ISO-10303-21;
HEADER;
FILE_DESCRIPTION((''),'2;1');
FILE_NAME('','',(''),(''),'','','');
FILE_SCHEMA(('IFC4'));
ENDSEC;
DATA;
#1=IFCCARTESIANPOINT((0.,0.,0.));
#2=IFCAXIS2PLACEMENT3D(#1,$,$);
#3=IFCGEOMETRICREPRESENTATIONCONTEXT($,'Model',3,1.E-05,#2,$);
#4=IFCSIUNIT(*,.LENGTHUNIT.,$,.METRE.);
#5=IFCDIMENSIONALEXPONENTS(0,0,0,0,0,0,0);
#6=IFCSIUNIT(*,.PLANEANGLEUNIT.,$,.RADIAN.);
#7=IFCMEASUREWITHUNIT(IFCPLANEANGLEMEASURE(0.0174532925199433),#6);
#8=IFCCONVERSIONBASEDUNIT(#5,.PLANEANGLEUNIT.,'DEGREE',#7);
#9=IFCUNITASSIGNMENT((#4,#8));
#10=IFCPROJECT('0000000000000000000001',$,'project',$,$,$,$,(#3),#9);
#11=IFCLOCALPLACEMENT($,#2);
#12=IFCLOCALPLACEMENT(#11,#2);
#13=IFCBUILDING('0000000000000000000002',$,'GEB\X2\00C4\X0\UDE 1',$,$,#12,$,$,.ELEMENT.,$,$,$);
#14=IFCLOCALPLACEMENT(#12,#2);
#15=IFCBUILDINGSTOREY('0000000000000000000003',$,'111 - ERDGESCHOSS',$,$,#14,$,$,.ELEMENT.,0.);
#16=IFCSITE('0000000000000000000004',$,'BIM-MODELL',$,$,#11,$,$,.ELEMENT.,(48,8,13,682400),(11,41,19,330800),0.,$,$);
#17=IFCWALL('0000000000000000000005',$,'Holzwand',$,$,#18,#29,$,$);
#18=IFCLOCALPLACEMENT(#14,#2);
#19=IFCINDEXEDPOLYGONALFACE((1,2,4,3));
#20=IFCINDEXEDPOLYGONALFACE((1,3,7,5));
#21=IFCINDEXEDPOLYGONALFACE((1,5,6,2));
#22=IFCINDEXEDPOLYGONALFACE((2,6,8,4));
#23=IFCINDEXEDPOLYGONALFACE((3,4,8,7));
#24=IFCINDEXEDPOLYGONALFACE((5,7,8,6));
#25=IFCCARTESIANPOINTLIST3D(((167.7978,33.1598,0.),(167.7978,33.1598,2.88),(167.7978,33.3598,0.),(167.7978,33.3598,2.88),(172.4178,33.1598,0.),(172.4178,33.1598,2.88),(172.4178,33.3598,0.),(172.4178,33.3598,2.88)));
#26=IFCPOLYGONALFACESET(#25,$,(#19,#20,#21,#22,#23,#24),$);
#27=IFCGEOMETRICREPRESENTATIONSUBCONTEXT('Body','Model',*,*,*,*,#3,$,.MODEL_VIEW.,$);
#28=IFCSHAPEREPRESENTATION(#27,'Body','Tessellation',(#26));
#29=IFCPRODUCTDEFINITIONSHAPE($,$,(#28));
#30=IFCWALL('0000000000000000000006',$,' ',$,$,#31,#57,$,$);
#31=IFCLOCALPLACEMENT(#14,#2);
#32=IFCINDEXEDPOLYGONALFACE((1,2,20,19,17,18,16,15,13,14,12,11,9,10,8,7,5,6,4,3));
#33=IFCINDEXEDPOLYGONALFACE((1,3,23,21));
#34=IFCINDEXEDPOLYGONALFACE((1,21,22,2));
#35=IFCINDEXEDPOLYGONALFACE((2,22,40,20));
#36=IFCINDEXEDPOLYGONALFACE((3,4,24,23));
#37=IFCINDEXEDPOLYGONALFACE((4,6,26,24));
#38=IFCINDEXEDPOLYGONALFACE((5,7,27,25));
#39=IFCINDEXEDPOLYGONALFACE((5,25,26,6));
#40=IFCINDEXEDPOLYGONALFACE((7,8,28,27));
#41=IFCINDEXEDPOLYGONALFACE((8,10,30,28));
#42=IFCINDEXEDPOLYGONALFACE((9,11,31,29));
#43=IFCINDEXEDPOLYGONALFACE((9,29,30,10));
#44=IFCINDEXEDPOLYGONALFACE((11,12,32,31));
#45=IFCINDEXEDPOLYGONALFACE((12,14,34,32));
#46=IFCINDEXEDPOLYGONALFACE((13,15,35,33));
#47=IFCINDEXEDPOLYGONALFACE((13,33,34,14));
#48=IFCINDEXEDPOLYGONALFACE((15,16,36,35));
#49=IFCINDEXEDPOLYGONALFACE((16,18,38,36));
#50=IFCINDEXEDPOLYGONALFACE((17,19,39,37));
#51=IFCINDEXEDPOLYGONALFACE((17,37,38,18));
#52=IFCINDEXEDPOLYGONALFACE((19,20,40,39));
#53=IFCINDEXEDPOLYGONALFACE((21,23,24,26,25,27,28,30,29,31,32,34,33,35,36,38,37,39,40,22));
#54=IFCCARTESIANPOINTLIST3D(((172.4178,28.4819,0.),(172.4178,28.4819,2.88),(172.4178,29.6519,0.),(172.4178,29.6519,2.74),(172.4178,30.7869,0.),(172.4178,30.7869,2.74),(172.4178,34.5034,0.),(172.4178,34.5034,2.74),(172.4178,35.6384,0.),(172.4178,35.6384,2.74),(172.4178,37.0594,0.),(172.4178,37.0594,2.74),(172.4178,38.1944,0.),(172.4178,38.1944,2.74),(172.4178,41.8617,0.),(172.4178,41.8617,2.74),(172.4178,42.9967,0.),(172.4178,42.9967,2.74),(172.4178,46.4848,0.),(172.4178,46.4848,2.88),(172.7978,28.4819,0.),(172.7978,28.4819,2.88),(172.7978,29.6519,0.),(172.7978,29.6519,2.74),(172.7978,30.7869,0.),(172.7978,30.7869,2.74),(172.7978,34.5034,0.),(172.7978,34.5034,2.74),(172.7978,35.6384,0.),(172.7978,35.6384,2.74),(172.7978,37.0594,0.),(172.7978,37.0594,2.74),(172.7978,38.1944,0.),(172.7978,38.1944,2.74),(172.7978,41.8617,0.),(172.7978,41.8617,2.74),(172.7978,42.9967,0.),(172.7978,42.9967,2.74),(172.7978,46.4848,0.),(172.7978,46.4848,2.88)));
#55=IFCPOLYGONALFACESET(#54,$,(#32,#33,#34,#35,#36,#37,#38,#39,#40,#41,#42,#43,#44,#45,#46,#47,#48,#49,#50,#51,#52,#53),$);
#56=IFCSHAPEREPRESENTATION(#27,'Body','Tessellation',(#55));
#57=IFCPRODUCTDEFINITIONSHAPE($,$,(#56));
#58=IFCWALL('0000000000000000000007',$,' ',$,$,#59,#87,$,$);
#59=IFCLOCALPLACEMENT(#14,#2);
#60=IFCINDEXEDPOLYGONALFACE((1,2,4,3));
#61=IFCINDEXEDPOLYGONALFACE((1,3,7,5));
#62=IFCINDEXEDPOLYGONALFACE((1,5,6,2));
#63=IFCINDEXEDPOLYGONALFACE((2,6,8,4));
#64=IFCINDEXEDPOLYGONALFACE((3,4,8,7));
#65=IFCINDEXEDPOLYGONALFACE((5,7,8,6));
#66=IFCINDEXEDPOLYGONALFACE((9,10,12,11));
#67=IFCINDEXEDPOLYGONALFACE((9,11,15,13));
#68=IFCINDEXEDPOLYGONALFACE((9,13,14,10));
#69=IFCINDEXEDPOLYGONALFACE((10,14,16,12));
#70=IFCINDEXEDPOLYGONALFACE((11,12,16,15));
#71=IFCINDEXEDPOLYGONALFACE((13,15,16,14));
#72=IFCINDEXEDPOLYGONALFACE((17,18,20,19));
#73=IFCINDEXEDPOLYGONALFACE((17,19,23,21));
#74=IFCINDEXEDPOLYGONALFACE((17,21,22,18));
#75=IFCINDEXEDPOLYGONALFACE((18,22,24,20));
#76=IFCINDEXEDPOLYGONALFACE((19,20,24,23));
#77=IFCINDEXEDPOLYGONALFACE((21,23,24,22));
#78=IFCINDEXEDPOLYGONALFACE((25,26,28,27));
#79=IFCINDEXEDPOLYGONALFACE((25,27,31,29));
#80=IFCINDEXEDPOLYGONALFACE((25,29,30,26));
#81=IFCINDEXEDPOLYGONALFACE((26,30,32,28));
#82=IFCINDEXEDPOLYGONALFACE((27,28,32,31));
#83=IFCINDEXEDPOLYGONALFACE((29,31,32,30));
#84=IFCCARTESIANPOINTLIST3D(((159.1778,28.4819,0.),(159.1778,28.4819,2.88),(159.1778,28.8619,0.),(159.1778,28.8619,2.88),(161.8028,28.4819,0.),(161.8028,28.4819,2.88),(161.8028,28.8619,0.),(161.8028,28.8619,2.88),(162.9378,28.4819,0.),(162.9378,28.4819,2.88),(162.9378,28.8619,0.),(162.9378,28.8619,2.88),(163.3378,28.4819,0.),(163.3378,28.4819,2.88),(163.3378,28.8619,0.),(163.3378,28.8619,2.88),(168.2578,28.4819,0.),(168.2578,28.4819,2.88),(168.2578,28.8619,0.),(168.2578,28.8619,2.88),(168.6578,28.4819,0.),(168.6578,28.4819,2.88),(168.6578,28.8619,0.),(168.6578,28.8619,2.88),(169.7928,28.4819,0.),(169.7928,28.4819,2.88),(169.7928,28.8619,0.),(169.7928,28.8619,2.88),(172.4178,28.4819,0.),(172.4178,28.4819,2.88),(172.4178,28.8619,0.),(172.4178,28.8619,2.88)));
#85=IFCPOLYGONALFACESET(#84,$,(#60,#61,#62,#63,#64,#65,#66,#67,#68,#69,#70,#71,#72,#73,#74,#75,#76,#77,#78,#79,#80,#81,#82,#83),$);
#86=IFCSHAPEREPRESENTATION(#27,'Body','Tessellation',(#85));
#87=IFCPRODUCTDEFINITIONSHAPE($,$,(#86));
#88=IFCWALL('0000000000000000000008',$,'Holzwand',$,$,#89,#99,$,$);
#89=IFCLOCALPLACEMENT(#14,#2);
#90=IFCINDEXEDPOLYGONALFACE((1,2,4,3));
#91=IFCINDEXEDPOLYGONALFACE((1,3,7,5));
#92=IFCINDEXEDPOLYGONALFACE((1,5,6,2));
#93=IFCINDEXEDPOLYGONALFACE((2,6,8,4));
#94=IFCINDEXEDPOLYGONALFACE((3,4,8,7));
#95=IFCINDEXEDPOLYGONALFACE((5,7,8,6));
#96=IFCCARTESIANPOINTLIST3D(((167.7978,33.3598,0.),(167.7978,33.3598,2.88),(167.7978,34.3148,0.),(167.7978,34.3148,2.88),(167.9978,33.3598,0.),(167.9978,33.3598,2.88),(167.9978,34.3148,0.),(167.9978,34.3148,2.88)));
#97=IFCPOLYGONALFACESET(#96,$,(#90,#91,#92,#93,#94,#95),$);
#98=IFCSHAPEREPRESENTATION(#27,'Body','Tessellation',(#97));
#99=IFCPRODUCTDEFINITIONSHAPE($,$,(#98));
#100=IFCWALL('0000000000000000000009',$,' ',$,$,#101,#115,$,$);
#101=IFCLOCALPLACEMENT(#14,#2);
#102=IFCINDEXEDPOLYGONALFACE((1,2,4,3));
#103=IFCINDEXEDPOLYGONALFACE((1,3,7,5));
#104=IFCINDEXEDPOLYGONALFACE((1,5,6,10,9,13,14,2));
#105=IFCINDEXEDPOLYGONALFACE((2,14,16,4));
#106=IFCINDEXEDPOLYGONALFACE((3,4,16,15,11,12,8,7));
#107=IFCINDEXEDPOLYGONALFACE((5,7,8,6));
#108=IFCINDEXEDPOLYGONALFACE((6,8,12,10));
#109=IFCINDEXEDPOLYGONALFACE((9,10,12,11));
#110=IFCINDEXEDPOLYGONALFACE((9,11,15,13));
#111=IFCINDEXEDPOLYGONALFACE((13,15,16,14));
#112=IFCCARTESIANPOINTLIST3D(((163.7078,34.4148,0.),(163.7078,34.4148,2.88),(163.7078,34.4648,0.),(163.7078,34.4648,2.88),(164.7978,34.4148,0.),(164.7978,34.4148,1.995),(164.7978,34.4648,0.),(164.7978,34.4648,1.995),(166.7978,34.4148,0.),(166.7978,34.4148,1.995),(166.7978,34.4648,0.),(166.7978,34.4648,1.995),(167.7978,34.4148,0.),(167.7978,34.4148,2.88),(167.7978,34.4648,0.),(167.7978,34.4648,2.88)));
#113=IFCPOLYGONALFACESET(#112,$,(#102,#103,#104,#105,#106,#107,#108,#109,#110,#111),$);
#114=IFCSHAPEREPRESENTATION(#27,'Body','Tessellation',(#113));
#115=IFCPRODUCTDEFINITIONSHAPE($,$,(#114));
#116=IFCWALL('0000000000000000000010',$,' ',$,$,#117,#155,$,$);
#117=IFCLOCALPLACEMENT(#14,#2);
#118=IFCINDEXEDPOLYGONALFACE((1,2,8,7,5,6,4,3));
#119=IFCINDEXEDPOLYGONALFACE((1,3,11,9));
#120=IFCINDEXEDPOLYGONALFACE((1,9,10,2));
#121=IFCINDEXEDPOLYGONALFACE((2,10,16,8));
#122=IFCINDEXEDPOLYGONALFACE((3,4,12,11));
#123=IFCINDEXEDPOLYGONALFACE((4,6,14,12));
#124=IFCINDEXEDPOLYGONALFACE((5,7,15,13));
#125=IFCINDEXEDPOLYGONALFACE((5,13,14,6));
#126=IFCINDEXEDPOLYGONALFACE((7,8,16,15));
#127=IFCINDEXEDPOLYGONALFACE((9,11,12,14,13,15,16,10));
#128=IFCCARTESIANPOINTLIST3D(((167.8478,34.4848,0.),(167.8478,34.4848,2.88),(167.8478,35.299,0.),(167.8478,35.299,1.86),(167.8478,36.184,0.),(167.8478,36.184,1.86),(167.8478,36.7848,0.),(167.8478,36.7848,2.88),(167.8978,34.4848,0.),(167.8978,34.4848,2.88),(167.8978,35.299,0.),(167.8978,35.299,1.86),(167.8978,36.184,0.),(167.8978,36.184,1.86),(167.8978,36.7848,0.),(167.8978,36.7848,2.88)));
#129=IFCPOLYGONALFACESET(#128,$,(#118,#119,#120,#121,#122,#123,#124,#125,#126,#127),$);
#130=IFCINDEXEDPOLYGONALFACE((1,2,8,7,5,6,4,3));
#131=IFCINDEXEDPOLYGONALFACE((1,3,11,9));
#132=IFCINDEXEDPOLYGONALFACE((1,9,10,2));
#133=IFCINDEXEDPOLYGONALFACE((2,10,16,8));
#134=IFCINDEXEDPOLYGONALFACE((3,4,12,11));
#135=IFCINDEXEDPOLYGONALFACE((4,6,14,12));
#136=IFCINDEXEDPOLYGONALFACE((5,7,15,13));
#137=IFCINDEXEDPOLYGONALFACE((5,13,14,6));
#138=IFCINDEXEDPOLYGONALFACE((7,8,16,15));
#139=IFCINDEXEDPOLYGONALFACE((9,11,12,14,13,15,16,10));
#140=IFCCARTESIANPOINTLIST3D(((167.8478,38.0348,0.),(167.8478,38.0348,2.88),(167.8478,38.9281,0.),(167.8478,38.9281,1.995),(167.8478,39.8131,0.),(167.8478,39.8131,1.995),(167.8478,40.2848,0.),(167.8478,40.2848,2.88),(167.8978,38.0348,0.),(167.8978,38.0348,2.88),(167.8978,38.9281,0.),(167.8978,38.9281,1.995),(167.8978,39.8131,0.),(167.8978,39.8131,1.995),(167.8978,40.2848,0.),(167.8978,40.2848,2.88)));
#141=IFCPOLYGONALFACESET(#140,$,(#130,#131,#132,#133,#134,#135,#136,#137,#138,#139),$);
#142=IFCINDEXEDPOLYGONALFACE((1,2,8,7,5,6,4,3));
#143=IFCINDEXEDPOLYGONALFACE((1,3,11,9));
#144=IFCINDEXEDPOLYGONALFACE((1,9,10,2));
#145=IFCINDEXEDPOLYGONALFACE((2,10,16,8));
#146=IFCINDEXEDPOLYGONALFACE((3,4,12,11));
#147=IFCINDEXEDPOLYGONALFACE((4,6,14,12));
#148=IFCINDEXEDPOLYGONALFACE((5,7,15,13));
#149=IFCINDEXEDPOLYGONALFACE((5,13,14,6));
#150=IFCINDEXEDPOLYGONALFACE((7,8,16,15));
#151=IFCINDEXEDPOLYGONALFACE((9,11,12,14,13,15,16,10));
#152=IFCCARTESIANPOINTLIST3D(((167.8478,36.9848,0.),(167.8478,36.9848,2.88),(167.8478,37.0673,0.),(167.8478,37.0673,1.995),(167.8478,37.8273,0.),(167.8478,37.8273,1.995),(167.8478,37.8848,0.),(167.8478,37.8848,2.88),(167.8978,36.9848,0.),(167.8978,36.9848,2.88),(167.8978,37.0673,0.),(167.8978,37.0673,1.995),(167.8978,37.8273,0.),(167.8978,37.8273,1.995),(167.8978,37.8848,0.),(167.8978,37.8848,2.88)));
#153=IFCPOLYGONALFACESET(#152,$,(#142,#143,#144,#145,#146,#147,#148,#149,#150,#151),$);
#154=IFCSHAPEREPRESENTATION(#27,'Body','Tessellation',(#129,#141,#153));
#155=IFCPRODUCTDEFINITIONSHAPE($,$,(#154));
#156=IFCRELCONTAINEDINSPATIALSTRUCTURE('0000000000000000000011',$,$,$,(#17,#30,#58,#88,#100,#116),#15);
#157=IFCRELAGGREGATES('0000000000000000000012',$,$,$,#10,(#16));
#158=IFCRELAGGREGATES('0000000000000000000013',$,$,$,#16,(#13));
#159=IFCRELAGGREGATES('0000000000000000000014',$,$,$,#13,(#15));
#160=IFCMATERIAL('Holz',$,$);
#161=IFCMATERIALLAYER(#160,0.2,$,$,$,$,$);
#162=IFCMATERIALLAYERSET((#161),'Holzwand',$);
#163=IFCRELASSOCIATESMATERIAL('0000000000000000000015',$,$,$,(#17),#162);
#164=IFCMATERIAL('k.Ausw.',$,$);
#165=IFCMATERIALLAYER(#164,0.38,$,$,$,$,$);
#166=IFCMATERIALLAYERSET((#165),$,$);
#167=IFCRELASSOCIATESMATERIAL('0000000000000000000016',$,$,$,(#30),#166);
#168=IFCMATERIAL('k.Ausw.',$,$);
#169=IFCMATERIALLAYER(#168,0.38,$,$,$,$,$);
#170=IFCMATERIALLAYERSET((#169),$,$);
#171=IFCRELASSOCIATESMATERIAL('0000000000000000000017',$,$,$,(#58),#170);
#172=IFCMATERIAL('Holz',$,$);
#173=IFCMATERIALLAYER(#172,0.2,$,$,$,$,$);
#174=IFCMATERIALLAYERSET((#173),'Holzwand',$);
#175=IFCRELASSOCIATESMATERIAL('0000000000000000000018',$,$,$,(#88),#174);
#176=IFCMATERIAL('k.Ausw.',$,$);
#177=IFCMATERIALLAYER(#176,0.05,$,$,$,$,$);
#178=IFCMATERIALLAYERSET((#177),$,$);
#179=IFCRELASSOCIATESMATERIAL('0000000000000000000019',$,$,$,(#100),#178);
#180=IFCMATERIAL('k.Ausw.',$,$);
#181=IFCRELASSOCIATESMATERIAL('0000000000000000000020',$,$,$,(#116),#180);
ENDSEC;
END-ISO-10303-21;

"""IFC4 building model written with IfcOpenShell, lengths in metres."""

from ifc_helpers import new_model, entity, si_unit, converted_unit, frame, frame_2d, origin, origin_with_axes, place, context, subcontext, project, spatial, polyline, rectangle, outline, extrude, material, layer, layer_set, layer_usage, element, save


model = new_model("IFC4")

# Units and contexts
model_context = context("Model", 3, precision=1e-05, world=origin())
body_context = subcontext(model_context, "Body", "Model", "MODEL_VIEW")
ifc_project = project(units=[si_unit("LENGTHUNIT", "METRE"), converted_unit("PLANEANGLEUNIT", "DEGREE", entity("IfcPlaneAngleMeasure", 0.0174532925199433), si_unit("PLANEANGLEUNIT", "RADIAN"), dimensions=[0, 0, 0, 0, 0, 0, 0])], contexts=[model_context])

# Site, building, storey
site_placement = place(None, origin())
site = spatial("IfcSite", under=ifc_project, at=site_placement, Name="BIM-MODELL", CompositionType="ELEMENT", RefLatitude=(48, 8, 13, 682400), RefLongitude=(11, 41, 19, 330800), RefElevation=0.0)
building_placement = place(site_placement, origin())
building = spatial("IfcBuilding", under=site, at=building_placement, Name="GEBÄUDE 1", CompositionType="ELEMENT")
storey_placement = place(building_placement, origin())
storey = spatial("IfcBuildingStorey", under=building, at=storey_placement, Name="111 - ERDGESCHOSS", CompositionType="ELEMENT", Elevation=0.0)

# Wall
ifc_material_1 = material(Name="Holz")
ifc_layer_1 = layer(ifc_material_1, 0.2)
ifc_layer_set_1 = layer_set([ifc_layer_1], Name="Holzwand")
ifc_layer_usage_1 = layer_usage(ifc_layer_set_1, "AXIS2", "POSITIVE", 0.0)
wall_1_placement = place(storey_placement, frame((167.7978, 33.1598, 0.0)))
element("IfcWall", 1, at=wall_1_placement, inside=storey, material=ifc_layer_usage_1, Name="Holzwand", context=body_context, shape_type="SweptSolid", body=[
    extrude(rectangle(XDim=4.62, YDim=0.2, at=frame_2d((2.31, 0.1), x_axis=(1.0, 0.0))), origin_with_axes(), (0.0, 0.0, 1.0), 2.88),
])

# Walls, openings
ifc_material_2 = material(Name="k.Ausw.")
ifc_layer_2 = layer(ifc_material_2, 0.38)
ifc_layer_set_2 = layer_set([ifc_layer_2])
ifc_layer_usage_2 = layer_usage(ifc_layer_set_2, "AXIS2", "POSITIVE", 0.0)
wall_2_placement = place(storey_placement, frame((172.7978, 28.4819, 0.0), z_axis=(0.0, 0.0, 1.0), x_axis=(0.0, 1.0, 0.0)))
wall_2 = element("IfcWall", 2, at=wall_2_placement, inside=storey, material=ifc_layer_usage_2, Name=" ", context=body_context, shape_type="SweptSolid", body=[
    extrude(rectangle(XDim=18.0029, YDim=0.38, at=frame_2d((9.0014, 0.19), x_axis=(1.0, 0.0))), origin_with_axes(), (0.0, 0.0, 1.0), 2.88),
])
opening_1_placement = place(wall_2_placement, frame((13.3798, 0.0, 0.0), z_axis=(0.0, 1.0, 0.0), x_axis=(0.0, 0.0, 1.0)))
element("IfcOpeningElement", 3, at=opening_1_placement, cuts=wall_2, ObjectType="Opening", context=body_context, shape_type="SweptSolid", body=[
    extrude(outline(polyline([(0.0, 1.135), (2.74, 1.135), (2.74, 0.0), (0.0, 0.0), (0.0, 1.135)])), origin_with_axes(), (0.0, 0.0, 1.0), 0.38),
])
opening_2_placement = place(wall_2_placement, frame((8.5775, 0.0, 0.0), z_axis=(0.0, 1.0, 0.0), x_axis=(0.0, 0.0, 1.0)))
element("IfcOpeningElement", 4, at=opening_2_placement, cuts=wall_2, ObjectType="Opening", context=body_context, shape_type="SweptSolid", body=[
    extrude(outline(polyline([(0.0, 1.135), (2.74, 1.135), (2.74, 0.0), (0.0, 0.0), (0.0, 1.135)])), origin_with_axes(), (0.0, 0.0, 1.0), 0.38),
])
opening_3_placement = place(wall_2_placement, frame((1.17, 0.0, 0.0), z_axis=(0.0, 1.0, 0.0), x_axis=(0.0, 0.0, 1.0)))
element("IfcOpeningElement", 5, at=opening_3_placement, cuts=wall_2, ObjectType="Opening", context=body_context, shape_type="SweptSolid", body=[
    extrude(outline(polyline([(0.0, 1.135), (2.74, 1.135), (2.74, 0.0), (0.0, 0.0), (0.0, 1.135)])), origin_with_axes(), (0.0, 0.0, 1.0), 0.38),
])
opening_4_placement = place(wall_2_placement, frame((6.0214, 0.0, 0.0), z_axis=(0.0, 1.0, 0.0), x_axis=(0.0, 0.0, 1.0)))
element("IfcOpeningElement", 6, at=opening_4_placement, cuts=wall_2, ObjectType="Opening", context=body_context, shape_type="SweptSolid", body=[
    extrude(outline(polyline([(0.0, 1.135), (2.74, 1.135), (2.74, 0.0), (0.0, 0.0), (0.0, 1.135)])), origin_with_axes(), (0.0, 0.0, 1.0), 0.38),
])
ifc_material_3 = material(Name="k.Ausw.")
ifc_layer_3 = layer(ifc_material_3, 0.38)
ifc_layer_set_3 = layer_set([ifc_layer_3])
ifc_layer_usage_3 = layer_usage(ifc_layer_set_3, "AXIS2", "POSITIVE", 0.0)
wall_3_placement = place(storey_placement, frame((159.1778, 28.4819, 0.0), z_axis=(0.0, 0.0, 1.0), x_axis=(1.0, 0.0, 0.0)))
wall_3 = element("IfcWall", 7, at=wall_3_placement, inside=storey, material=ifc_layer_usage_3, Name=" ", context=body_context, shape_type="SweptSolid", body=[
    extrude(rectangle(XDim=13.24, YDim=0.38, at=frame_2d((6.62, 0.19), x_axis=(1.0, 0.0))), origin_with_axes(), (0.0, 0.0, 1.0), 2.88),
])
opening_5_placement = place(wall_3_placement, frame((9.48, 0.0, 0.0), z_axis=(0.0, 1.0, 0.0), x_axis=(0.0, 0.0, 1.0)))
element("IfcOpeningElement", 8, at=opening_5_placement, cuts=wall_3, ObjectType="Opening", context=body_context, shape_type="SweptSolid", body=[
    extrude(outline(polyline([(0.0, 1.135), (2.88, 1.135), (2.88, 0.0), (0.0, 0.0), (0.0, 1.135)])), origin_with_axes(), (0.0, 0.0, 1.0), 0.38),
])
opening_6_placement = place(wall_3_placement, frame((2.625, 0.0, 0.0), z_axis=(0.0, 1.0, 0.0), x_axis=(0.0, 0.0, 1.0)))
element("IfcOpeningElement", 9, at=opening_6_placement, cuts=wall_3, ObjectType="Opening", context=body_context, shape_type="SweptSolid", body=[
    extrude(outline(polyline([(0.0, 1.135), (2.88, 1.135), (2.88, 0.0), (0.0, 0.0), (0.0, 1.135)])), origin_with_axes(), (0.0, 0.0, 1.0), 0.38),
])
opening_7_placement = place(wall_3_placement, frame((4.16, 0.0, 0.0), z_axis=(0.0, 1.0, 0.0), x_axis=(0.0, 0.0, 1.0)))
element("IfcOpeningElement", 10, at=opening_7_placement, cuts=wall_3, ObjectType="Opening", context=body_context, shape_type="SweptSolid", body=[
    extrude(outline(polyline([(0.0, 4.92), (2.88, 4.92), (2.88, 0.0), (0.0, 0.0), (0.0, 4.92)])), origin_with_axes(), (0.0, 0.0, 1.0), 0.38),
])

# Wall
ifc_material_4 = material(Name="Holz")
ifc_layer_4 = layer(ifc_material_4, 0.2)
ifc_layer_set_4 = layer_set([ifc_layer_4], Name="Holzwand")
ifc_layer_usage_4 = layer_usage(ifc_layer_set_4, "AXIS2", "POSITIVE", 0.0)
wall_4_placement = place(storey_placement, frame((167.9978, 33.3598, 0.0), z_axis=(0.0, 0.0, 1.0), x_axis=(0.0, 1.0, 0.0)))
element("IfcWall", 11, at=wall_4_placement, inside=storey, material=ifc_layer_usage_4, Name="Holzwand", context=body_context, shape_type="SweptSolid", body=[
    extrude(rectangle(XDim=0.955, YDim=0.2, at=frame_2d((0.4775, 0.1), x_axis=(1.0, 0.0))), origin_with_axes(), (0.0, 0.0, 1.0), 2.88),
])

# Wall, opening
ifc_material_5 = material(Name="k.Ausw.")
ifc_layer_5 = layer(ifc_material_5, 0.05)
ifc_layer_set_5 = layer_set([ifc_layer_5])
ifc_layer_usage_5 = layer_usage(ifc_layer_set_5, "AXIS2", "POSITIVE", 0.0)
wall_5_placement = place(storey_placement, frame((163.7078, 34.4148, 0.0), z_axis=(0.0, 0.0, 1.0), x_axis=(1.0, 0.0, 0.0)))
wall_5 = element("IfcWall", 12, at=wall_5_placement, inside=storey, material=ifc_layer_usage_5, Name=" ", context=body_context, shape_type="SweptSolid", body=[
    extrude(rectangle(XDim=4.09, YDim=0.05, at=frame_2d((2.045, 0.025), x_axis=(1.0, 0.0))), origin_with_axes(), (0.0, 0.0, 1.0), 2.88),
])
opening_8_placement = place(wall_5_placement, frame((1.09, 0.0, -0.14), z_axis=(0.0, 1.0, 0.0), x_axis=(0.0, 0.0, 1.0)))
element("IfcOpeningElement", 13, at=opening_8_placement, cuts=wall_5, ObjectType="Opening", context=body_context, shape_type="SweptSolid", body=[
    extrude(outline(polyline([(0.0, 2.0), (2.135, 2.0), (2.135, 0.0), (0.0, 0.0), (0.0, 2.0)])), origin_with_axes(), (0.0, 0.0, 1.0), 0.05),
])

# Wall, openings
ifc_material_6 = material(Name="k.Ausw.")
wall_6_placement = place(storey_placement, frame((167.8978, 34.4848, 0.0), z_axis=(0.0, 0.0, 1.0), x_axis=(0.0, 1.0, 0.0)))
wall_6 = element("IfcWall", 14, at=wall_6_placement, inside=storey, material=ifc_material_6, Name=" ", context=body_context, shape_type="SweptSolid", body=[
    extrude(rectangle(XDim=2.3, YDim=0.05, at=frame_2d((1.15, 0.025), x_axis=(1.0, 0.0))), origin_with_axes(), (0.0, 0.0, 1.0), 2.88),
    extrude(rectangle(XDim=2.25, YDim=0.05, at=frame_2d((1.125, 0.025), x_axis=(1.0, 0.0))), frame((3.55, 0.0, 0.0), z_axis=(0.0, 0.0, 1.0), x_axis=(1.0, 0.0, 0.0)), (0.0, 0.0, 1.0), 2.88),
    extrude(rectangle(XDim=0.9, YDim=0.05, at=frame_2d((0.45, 0.025), x_axis=(1.0, 0.0))), frame((2.5, 0.0, 0.0), z_axis=(0.0, 0.0, 1.0), x_axis=(1.0, 0.0, 0.0)), (0.0, 0.0, 1.0), 2.88),
])
opening_9_placement = place(wall_6_placement, frame((0.8142, 0.0, -0.15), z_axis=(0.0, 1.0, 0.0), x_axis=(0.0, 0.0, 1.0)))
element("IfcOpeningElement", 15, at=opening_9_placement, cuts=wall_6, ObjectType="Opening", context=body_context, shape_type="SweptSolid", body=[
    extrude(outline(polyline([(0.0, 0.885), (2.01, 0.885), (2.01, 0.0), (0.0, 0.0), (0.0, 0.885)])), origin_with_axes(), (0.0, 0.0, 1.0), 0.05),
])
opening_10_placement = place(wall_6_placement, frame((5.3283, 0.05, -0.14), z_axis=(0.0, -1.0, 0.0), x_axis=(0.0, 0.0, 1.0)))
element("IfcOpeningElement", 16, at=opening_10_placement, cuts=wall_6, ObjectType="Opening", context=body_context, shape_type="SweptSolid", body=[
    extrude(outline(polyline([(0.0, 0.885), (2.135, 0.885), (2.135, 0.0), (0.0, 0.0), (0.0, 0.885)])), origin_with_axes(), (0.0, 0.0, 1.0), 0.05),
])
opening_11_placement = place(wall_6_placement, frame((2.5825, 0.0, -0.14), z_axis=(0.0, 1.0, 0.0), x_axis=(0.0, 0.0, 1.0)))
element("IfcOpeningElement", 17, at=opening_11_placement, cuts=wall_6, ObjectType="Opening", context=body_context, shape_type="SweptSolid", body=[
    extrude(outline(polyline([(0.0, 0.76), (2.135, 0.76), (2.135, 0.0), (0.0, 0.0), (0.0, 0.76)])), origin_with_axes(), (0.0, 0.0, 1.0), 0.05),
])

save(model, "model.ifc")
